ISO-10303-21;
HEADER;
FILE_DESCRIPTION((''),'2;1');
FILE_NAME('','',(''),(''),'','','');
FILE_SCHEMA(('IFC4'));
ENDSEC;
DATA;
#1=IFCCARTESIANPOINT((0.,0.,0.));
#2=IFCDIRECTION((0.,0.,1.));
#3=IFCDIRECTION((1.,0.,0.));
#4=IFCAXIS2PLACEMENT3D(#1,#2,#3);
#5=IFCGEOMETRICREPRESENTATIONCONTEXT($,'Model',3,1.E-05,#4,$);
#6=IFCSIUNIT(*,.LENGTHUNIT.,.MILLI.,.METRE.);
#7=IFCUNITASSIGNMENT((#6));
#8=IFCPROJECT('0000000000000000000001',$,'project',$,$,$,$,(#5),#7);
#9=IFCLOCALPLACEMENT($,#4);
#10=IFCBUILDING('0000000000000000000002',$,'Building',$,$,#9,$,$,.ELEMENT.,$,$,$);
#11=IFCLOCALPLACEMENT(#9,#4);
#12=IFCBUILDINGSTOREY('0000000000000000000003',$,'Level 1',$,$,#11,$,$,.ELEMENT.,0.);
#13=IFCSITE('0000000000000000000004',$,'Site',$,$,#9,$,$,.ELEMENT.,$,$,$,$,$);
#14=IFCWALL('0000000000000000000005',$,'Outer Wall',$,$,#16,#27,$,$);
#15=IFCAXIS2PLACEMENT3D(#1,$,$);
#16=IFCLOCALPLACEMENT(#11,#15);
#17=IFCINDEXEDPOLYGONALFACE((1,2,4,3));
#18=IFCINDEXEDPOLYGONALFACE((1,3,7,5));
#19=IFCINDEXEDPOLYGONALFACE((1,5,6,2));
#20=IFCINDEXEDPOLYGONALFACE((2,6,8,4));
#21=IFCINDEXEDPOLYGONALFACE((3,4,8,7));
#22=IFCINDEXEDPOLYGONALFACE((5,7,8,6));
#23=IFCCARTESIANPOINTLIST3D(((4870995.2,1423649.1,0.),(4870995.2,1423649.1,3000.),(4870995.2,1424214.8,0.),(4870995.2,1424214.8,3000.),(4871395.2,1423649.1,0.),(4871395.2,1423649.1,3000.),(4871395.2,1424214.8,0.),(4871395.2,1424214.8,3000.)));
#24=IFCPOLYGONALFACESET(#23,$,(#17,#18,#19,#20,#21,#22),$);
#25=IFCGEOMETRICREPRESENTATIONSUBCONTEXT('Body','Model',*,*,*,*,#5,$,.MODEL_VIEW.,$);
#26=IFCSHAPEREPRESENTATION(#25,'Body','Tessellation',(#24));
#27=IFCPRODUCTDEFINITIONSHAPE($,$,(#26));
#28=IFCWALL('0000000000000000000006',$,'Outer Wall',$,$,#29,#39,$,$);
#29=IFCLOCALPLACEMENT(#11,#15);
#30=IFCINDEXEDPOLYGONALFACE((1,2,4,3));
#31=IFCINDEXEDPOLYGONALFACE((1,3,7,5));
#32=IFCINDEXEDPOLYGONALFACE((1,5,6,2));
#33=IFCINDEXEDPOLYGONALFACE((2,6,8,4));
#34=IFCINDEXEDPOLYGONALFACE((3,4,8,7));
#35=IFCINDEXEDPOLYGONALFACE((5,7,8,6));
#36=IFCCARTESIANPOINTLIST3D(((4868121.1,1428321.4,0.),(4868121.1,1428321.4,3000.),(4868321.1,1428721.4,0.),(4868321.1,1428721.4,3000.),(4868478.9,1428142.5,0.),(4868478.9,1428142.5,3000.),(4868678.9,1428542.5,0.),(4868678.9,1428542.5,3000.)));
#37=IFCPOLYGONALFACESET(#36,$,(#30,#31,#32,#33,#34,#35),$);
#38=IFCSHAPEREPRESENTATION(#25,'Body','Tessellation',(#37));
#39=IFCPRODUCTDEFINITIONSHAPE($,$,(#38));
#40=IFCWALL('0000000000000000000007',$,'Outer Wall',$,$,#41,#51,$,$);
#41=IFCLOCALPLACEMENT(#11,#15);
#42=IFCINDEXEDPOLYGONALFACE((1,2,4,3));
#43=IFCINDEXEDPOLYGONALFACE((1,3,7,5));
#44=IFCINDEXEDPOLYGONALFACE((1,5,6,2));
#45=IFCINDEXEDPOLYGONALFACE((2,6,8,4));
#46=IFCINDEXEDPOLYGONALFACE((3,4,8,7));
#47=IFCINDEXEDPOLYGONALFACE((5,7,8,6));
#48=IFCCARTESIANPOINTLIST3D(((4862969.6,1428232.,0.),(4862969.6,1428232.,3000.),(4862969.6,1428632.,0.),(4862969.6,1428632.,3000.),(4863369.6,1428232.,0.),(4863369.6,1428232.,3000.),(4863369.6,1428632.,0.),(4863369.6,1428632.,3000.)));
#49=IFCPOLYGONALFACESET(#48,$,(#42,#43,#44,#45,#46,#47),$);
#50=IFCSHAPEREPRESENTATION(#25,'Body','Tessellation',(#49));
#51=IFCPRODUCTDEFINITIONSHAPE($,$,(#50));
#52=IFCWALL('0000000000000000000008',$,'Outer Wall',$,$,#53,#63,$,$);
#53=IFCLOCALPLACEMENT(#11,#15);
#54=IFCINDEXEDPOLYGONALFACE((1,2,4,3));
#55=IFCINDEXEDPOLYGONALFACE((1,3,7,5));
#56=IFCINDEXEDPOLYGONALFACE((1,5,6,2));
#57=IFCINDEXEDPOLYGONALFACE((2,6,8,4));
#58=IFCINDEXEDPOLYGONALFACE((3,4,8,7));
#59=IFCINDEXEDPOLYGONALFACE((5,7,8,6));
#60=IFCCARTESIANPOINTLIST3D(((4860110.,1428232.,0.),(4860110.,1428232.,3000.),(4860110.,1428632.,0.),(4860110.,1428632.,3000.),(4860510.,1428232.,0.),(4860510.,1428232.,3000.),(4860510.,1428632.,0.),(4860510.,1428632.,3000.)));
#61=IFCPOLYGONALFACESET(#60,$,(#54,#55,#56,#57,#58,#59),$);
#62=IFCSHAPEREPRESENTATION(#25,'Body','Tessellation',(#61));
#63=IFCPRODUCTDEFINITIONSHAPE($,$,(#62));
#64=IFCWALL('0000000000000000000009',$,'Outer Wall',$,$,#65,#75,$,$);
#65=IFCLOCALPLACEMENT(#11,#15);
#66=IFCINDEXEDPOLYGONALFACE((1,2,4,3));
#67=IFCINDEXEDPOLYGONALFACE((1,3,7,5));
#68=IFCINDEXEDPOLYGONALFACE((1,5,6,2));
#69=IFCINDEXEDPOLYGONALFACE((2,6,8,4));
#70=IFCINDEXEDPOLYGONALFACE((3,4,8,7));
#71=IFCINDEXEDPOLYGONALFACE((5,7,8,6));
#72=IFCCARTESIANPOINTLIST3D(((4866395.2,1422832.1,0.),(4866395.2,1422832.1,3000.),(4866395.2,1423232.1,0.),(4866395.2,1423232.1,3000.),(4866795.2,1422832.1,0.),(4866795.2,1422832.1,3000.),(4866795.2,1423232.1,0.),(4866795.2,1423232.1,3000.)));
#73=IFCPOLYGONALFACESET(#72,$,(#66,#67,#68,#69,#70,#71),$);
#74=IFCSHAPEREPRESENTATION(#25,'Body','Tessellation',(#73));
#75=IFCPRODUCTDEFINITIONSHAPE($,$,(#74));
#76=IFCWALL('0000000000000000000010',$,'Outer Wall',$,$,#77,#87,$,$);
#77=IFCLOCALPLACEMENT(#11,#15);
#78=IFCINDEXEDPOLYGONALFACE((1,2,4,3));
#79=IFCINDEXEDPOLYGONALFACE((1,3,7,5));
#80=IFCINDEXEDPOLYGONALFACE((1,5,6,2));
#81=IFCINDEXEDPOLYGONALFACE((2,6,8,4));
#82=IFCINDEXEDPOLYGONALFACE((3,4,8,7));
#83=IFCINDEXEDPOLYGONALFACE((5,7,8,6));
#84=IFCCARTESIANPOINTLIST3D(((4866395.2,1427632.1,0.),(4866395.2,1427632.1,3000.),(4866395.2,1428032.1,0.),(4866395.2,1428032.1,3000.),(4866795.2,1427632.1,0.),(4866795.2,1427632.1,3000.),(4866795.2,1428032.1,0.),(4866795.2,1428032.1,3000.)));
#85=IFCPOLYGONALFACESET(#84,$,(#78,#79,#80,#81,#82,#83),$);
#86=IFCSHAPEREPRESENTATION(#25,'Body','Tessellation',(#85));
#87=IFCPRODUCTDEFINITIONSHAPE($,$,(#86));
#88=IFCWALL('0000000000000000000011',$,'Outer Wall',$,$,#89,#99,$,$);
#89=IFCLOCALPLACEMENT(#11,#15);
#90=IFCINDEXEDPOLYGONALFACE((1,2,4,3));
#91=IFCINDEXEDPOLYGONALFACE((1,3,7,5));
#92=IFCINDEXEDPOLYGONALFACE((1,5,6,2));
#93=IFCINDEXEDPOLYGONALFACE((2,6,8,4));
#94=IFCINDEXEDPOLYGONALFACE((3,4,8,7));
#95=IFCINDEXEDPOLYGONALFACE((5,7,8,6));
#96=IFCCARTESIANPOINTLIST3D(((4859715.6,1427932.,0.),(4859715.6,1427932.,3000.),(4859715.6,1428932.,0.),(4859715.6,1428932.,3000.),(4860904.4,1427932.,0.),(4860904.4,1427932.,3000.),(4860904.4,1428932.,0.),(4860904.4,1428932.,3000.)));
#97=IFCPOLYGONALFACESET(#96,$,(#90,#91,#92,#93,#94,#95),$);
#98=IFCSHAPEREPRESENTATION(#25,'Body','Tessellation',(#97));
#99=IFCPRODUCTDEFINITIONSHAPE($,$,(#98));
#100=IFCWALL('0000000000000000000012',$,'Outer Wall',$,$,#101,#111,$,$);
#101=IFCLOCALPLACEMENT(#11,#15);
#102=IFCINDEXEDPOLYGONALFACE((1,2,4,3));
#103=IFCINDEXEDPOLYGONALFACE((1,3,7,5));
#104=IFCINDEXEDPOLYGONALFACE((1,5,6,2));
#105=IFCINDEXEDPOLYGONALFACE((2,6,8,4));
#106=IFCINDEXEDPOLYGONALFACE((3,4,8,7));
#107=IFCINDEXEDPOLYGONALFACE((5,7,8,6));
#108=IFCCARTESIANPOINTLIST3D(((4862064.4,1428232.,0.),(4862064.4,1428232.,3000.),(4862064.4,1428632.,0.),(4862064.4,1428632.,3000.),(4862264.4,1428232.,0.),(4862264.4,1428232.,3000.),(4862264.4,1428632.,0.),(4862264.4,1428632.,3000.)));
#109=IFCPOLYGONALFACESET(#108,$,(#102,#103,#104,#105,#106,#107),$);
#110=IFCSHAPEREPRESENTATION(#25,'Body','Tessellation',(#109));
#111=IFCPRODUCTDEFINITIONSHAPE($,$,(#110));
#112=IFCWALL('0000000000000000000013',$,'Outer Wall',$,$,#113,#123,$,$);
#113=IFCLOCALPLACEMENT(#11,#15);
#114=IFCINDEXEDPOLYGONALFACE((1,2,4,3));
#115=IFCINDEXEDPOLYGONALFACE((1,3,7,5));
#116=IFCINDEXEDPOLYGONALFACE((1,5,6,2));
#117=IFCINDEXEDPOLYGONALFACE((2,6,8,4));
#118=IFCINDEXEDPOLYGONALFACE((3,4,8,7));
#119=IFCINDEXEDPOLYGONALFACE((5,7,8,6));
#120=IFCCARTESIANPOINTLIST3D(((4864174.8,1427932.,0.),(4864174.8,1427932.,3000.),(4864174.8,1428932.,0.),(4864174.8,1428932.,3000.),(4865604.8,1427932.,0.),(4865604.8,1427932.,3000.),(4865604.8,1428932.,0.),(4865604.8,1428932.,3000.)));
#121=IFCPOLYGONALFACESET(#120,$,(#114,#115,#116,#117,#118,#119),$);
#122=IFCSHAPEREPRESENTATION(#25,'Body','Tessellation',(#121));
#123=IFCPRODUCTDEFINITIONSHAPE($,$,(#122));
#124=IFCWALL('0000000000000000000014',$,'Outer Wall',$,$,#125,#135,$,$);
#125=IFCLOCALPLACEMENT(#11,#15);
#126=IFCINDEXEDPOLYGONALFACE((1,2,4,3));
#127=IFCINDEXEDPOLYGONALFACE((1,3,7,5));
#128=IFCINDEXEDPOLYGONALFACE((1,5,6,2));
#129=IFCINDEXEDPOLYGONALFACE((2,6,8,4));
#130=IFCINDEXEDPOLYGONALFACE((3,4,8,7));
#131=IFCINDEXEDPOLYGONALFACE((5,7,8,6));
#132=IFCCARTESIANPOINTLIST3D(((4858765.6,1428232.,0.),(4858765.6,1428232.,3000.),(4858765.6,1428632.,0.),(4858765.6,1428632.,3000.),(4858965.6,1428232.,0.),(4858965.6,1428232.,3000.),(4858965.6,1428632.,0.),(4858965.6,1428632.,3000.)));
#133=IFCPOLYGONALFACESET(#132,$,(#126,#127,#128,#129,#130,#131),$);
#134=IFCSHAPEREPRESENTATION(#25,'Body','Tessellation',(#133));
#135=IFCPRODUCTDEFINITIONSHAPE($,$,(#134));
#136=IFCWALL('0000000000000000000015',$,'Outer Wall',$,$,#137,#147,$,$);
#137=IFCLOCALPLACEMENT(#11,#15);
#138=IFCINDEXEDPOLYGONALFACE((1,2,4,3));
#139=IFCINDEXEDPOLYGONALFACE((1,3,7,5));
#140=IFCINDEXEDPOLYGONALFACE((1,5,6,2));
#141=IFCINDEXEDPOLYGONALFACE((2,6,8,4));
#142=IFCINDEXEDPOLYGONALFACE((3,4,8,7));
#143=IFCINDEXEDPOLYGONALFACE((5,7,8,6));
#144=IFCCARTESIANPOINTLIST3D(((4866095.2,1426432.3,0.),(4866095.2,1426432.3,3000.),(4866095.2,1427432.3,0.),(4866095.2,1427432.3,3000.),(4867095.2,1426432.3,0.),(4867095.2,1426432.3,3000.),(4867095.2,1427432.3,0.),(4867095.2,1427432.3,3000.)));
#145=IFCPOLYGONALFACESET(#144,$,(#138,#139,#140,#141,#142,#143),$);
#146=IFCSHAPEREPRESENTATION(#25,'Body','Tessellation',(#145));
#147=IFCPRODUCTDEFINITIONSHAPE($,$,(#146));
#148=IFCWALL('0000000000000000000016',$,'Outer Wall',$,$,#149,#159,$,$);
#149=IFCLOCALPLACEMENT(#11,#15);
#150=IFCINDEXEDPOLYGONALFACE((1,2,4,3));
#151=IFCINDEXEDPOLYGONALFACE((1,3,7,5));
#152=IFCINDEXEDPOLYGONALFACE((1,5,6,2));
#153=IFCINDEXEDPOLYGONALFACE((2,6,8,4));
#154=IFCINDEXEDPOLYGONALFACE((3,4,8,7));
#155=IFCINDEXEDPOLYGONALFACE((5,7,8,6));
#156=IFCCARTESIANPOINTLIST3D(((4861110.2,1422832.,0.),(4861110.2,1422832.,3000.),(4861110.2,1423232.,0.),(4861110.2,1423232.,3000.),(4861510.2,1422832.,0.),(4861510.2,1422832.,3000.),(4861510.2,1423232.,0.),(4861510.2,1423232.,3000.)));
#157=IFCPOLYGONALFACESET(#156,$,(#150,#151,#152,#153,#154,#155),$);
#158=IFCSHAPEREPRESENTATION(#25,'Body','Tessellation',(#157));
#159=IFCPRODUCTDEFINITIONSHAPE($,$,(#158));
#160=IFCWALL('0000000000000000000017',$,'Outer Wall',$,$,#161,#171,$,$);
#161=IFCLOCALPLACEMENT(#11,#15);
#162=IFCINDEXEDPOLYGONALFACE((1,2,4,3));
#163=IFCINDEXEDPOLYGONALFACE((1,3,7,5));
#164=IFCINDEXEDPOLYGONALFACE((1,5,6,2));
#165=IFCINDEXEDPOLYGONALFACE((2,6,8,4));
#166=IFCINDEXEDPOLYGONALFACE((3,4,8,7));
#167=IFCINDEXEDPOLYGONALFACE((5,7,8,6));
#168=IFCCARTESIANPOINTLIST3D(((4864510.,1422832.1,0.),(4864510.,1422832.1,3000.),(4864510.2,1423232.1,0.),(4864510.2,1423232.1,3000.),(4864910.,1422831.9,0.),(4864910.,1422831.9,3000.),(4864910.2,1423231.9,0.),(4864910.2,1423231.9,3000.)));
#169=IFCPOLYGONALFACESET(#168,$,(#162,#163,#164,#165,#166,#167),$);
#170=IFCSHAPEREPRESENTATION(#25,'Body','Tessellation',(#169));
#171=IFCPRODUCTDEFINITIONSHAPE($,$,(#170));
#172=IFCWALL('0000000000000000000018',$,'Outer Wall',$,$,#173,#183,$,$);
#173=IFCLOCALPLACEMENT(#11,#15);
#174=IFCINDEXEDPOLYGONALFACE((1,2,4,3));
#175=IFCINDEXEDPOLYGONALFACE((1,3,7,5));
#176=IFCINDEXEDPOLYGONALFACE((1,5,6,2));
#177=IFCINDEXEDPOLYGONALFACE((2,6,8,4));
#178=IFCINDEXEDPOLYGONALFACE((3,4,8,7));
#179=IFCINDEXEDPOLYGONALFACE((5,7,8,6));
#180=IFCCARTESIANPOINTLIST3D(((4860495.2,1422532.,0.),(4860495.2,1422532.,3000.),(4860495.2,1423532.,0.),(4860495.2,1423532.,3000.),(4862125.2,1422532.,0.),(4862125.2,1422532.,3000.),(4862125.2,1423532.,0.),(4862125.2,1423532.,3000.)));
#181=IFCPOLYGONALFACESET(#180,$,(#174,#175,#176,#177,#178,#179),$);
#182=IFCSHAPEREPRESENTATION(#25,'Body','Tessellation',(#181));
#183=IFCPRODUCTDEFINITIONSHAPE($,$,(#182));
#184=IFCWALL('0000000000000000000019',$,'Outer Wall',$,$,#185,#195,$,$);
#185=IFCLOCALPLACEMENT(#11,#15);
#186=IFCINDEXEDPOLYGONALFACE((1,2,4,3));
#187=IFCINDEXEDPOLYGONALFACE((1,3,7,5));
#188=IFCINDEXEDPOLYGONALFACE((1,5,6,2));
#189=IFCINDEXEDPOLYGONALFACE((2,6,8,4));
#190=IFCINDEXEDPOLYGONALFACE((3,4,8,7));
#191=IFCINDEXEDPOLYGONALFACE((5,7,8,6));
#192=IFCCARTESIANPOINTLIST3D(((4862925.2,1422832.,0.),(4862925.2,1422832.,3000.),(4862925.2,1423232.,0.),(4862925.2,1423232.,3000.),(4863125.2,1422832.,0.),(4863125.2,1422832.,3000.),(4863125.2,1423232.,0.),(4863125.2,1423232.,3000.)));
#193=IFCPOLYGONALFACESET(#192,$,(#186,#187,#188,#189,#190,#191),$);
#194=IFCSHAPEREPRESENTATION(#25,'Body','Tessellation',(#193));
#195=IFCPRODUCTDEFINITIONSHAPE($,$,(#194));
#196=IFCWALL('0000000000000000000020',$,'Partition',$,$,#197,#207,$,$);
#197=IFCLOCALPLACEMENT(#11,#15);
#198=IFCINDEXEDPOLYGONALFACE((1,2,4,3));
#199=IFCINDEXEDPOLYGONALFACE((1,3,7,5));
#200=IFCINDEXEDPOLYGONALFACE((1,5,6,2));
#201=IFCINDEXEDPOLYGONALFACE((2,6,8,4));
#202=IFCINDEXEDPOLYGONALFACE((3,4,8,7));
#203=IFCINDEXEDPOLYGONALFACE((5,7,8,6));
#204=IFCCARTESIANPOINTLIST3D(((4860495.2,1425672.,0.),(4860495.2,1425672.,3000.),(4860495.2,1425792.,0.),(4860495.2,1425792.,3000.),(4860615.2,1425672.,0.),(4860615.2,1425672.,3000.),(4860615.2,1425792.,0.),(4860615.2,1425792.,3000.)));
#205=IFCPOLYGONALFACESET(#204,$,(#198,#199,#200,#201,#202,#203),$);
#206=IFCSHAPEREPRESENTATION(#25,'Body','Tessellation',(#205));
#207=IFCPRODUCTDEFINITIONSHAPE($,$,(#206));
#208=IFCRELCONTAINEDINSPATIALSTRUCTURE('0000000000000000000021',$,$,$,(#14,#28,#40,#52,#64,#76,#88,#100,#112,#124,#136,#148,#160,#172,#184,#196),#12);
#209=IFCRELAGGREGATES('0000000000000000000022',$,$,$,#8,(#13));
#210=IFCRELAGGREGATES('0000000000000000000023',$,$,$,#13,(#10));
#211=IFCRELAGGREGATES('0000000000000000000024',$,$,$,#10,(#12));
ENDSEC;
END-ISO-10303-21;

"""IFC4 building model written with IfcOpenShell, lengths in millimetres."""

from ifc_helpers import new_model, si_unit, frame, frame_2d, origin_with_axes, place, context, subcontext, project, spatial, rectangle, extrude, element, save


model = new_model("IFC4")

# Units and contexts
model_context = context("Model", 3, precision=1e-05, world=origin_with_axes())
body_context = subcontext(model_context, "Body", "Model", "MODEL_VIEW")
ifc_project = project(units=[si_unit("LENGTHUNIT", "METRE", prefix="MILLI")], contexts=[model_context])

# Site, building, storey
placement = place(None, origin_with_axes())
site = spatial("IfcSite", under=ifc_project, at=placement, Name="Site", CompositionType="ELEMENT")
building = spatial("IfcBuilding", under=site, at=placement, Name="Building", CompositionType="ELEMENT")
storey_placement = place(placement, origin_with_axes())
storey = spatial("IfcBuildingStorey", under=building, at=storey_placement, Name="Level 1", CompositionType="ELEMENT", Elevation=0.0)

# Walls
wall_1_placement = place(placement, frame((4871395.2, 1423932.0, 0.0), z_axis=(0.0, 0.0, 1.0), x_axis=(-1.0, 0.0, 0.0)))
element("IfcWall", 1, at=wall_1_placement, inside=storey, Name="Outer Wall", context=body_context, shape_type="SweptSolid", body=[
    extrude(rectangle(XDim=400.0, YDim=565.7, at=frame_2d((200.0, 0.0), x_axis=(1.0, 0.0))), origin_with_axes(), (0.0, 0.0, 1.0), 3000.0),
])
wall_2_placement = place(placement, frame((4868300.0, 1428232.0, 0.0), z_axis=(0.0, 0.0, 1.0), x_axis=(0.447214, 0.894427, 0.0)))
element("IfcWall", 2, at=wall_2_placement, inside=storey, Name="Outer Wall", context=body_context, shape_type="SweptSolid", body=[
    extrude(rectangle(XDim=447.2, YDim=400.0, at=frame_2d((223.6, 0.0), x_axis=(1.0, 0.0))), origin_with_axes(), (0.0, 0.0, 1.0), 3000.0),
])
wall_3_placement = place(placement, frame((4863169.6, 1428232.0, 0.0), z_axis=(0.0, 0.0, 1.0), x_axis=(0.0, 1.0, 0.0)))
element("IfcWall", 3, at=wall_3_placement, inside=storey, Name="Outer Wall", context=body_context, shape_type="SweptSolid", body=[
    extrude(rectangle(XDim=400.0, YDim=400.0, at=frame_2d((200.0, 0.0), x_axis=(1.0, 0.0))), origin_with_axes(), (0.0, 0.0, 1.0), 3000.0),
])
wall_4_placement = place(placement, frame((4860310.0, 1428232.0, 0.0), z_axis=(0.0, 0.0, 1.0), x_axis=(0.0, 1.0, 0.0)))
element("IfcWall", 4, at=wall_4_placement, inside=storey, Name="Outer Wall", context=body_context, shape_type="SweptSolid", body=[
    extrude(rectangle(XDim=400.0, YDim=400.0, at=frame_2d((200.0, 0.0), x_axis=(1.0, 0.0))), origin_with_axes(), (0.0, 0.0, 1.0), 3000.0),
])
for number, where, z_axis, x_axis, name in (
    (5, (4866395.2, 1423032.1, 0.0), (0.0, 0.0, 1.0), (1.0, 0.0, 0.0), "Outer Wall"),
    (6, (4866395.2, 1427832.1, 0.0), (0.0, 0.0, 1.0), (1.0, 0.0, 0.0), "Outer Wall"),
):
    element("IfcWall", number, at=place(placement, frame(where, z_axis=z_axis, x_axis=x_axis)), inside=storey, Name=name, context=body_context, shape_type="SweptSolid", body=[
        extrude(rectangle(XDim=400.0, YDim=400.0, at=frame_2d((200.0, 0.0), x_axis=(1.0, 0.0))), origin_with_axes(), (0.0, 0.0, 1.0), 3000.0),
    ])
wall_5_placement = place(placement, frame((4860904.4, 1428432.0, 0.0), z_axis=(0.0, 0.0, 1.0), x_axis=(-1.0, 0.0, 0.0)))
element("IfcWall", 7, at=wall_5_placement, inside=storey, Name="Outer Wall", context=body_context, shape_type="SweptSolid", body=[
    extrude(rectangle(XDim=1188.8, YDim=1000.0, at=frame_2d((594.4, 0.0), x_axis=(1.0, 0.0))), origin_with_axes(), (0.0, 0.0, 1.0), 3000.0),
])
wall_6_placement = place(placement, frame((4862164.4, 1428232.0, 0.0), z_axis=(0.0, 0.0, 1.0), x_axis=(0.0, 1.0, 0.0)))
element("IfcWall", 8, at=wall_6_placement, inside=storey, Name="Outer Wall", context=body_context, shape_type="SweptSolid", body=[
    extrude(rectangle(XDim=400.0, YDim=200.0, at=frame_2d((200.0, 0.0), x_axis=(1.0, 0.0))), origin_with_axes(), (0.0, 0.0, 1.0), 3000.0),
])
wall_7_placement = place(placement, frame((4864174.8, 1428432.0, 0.0), z_axis=(0.0, 0.0, 1.0), x_axis=(1.0, 0.0, 0.0)))
element("IfcWall", 9, at=wall_7_placement, inside=storey, Name="Outer Wall", context=body_context, shape_type="SweptSolid", body=[
    extrude(rectangle(XDim=1430.0, YDim=1000.0, at=frame_2d((715.0, 0.0), x_axis=(1.0, 0.0))), origin_with_axes(), (0.0, 0.0, 1.0), 3000.0),
])
wall_8_placement = place(placement, frame((4858865.6, 1428232.0, 0.0), z_axis=(0.0, 0.0, 1.0), x_axis=(0.0, 1.0, 0.0)))
element("IfcWall", 10, at=wall_8_placement, inside=storey, Name="Outer Wall", context=body_context, shape_type="SweptSolid", body=[
    extrude(rectangle(XDim=400.0, YDim=200.0, at=frame_2d((200.0, 0.0), x_axis=(1.0, 0.0))), origin_with_axes(), (0.0, 0.0, 1.0), 3000.0),
])
wall_9_placement = place(placement, frame((4866595.2, 1427432.3, 0.0), z_axis=(0.0, 0.0, 1.0), x_axis=(0.0, -1.0, 0.0)))
element("IfcWall", 11, at=wall_9_placement, inside=storey, Name="Outer Wall", context=body_context, shape_type="SweptSolid", body=[
    extrude(rectangle(XDim=1000.0, YDim=1000.0, at=frame_2d((500.0, 0.0), x_axis=(1.0, 0.0))), origin_with_axes(), (0.0, 0.0, 1.0), 3000.0),
])
wall_10_placement = place(placement, frame((4861310.2, 1423232.0, 0.0), z_axis=(0.0, 0.0, 1.0), x_axis=(0.0, -1.0, 0.0)))
element("IfcWall", 12, at=wall_10_placement, inside=storey, Name="Outer Wall", context=body_context, shape_type="SweptSolid", body=[
    extrude(rectangle(XDim=400.0, YDim=400.0, at=frame_2d((200.0, 0.0), x_axis=(1.0, 0.0))), origin_with_axes(), (0.0, 0.0, 1.0), 3000.0),
])
wall_11_placement = place(placement, frame((4864710.2, 1423232.0, 0.0), z_axis=(0.0, 0.0, 1.0), x_axis=(-0.000505, -1.0, 0.0)))
element("IfcWall", 13, at=wall_11_placement, inside=storey, Name="Outer Wall", context=body_context, shape_type="SweptSolid", body=[
    extrude(rectangle(XDim=400.0, YDim=400.0, at=frame_2d((200.0, 0.0), x_axis=(1.0, 0.0))), origin_with_axes(), (0.0, 0.0, 1.0), 3000.0),
])
wall_12_placement = place(placement, frame((4860495.2, 1423032.0, 0.0), z_axis=(0.0, 0.0, 1.0), x_axis=(1.0, 0.0, 0.0)))
element("IfcWall", 14, at=wall_12_placement, inside=storey, Name="Outer Wall", context=body_context, shape_type="SweptSolid", body=[
    extrude(rectangle(XDim=1630.0, YDim=1000.0, at=frame_2d((815.0, 0.0), x_axis=(1.0, 0.0))), origin_with_axes(), (0.0, 0.0, 1.0), 3000.0),
])
wall_13_placement = place(placement, frame((4863025.2, 1423232.0, 0.0), z_axis=(0.0, 0.0, 1.0), x_axis=(0.0, -1.0, 0.0)))
element("IfcWall", 15, at=wall_13_placement, inside=storey, Name="Outer Wall", context=body_context, shape_type="SweptSolid", body=[
    extrude(rectangle(XDim=400.0, YDim=200.0, at=frame_2d((200.0, 0.0), x_axis=(1.0, 0.0))), origin_with_axes(), (0.0, 0.0, 1.0), 3000.0),
])
wall_14_placement = place(placement, frame((4860495.2, 1425732.0, 0.0), z_axis=(0.0, 0.0, 1.0), x_axis=(1.0, 0.0, 0.0)))
element("IfcWall", 16, at=wall_14_placement, inside=storey, Name="Partition", context=body_context, shape_type="SweptSolid", body=[
    extrude(rectangle(XDim=120.0, YDim=120.0, at=frame_2d((60.0, 0.0), x_axis=(1.0, 0.0))), origin_with_axes(), (0.0, 0.0, 1.0), 3000.0),
])

save(model, "model.ifc")
